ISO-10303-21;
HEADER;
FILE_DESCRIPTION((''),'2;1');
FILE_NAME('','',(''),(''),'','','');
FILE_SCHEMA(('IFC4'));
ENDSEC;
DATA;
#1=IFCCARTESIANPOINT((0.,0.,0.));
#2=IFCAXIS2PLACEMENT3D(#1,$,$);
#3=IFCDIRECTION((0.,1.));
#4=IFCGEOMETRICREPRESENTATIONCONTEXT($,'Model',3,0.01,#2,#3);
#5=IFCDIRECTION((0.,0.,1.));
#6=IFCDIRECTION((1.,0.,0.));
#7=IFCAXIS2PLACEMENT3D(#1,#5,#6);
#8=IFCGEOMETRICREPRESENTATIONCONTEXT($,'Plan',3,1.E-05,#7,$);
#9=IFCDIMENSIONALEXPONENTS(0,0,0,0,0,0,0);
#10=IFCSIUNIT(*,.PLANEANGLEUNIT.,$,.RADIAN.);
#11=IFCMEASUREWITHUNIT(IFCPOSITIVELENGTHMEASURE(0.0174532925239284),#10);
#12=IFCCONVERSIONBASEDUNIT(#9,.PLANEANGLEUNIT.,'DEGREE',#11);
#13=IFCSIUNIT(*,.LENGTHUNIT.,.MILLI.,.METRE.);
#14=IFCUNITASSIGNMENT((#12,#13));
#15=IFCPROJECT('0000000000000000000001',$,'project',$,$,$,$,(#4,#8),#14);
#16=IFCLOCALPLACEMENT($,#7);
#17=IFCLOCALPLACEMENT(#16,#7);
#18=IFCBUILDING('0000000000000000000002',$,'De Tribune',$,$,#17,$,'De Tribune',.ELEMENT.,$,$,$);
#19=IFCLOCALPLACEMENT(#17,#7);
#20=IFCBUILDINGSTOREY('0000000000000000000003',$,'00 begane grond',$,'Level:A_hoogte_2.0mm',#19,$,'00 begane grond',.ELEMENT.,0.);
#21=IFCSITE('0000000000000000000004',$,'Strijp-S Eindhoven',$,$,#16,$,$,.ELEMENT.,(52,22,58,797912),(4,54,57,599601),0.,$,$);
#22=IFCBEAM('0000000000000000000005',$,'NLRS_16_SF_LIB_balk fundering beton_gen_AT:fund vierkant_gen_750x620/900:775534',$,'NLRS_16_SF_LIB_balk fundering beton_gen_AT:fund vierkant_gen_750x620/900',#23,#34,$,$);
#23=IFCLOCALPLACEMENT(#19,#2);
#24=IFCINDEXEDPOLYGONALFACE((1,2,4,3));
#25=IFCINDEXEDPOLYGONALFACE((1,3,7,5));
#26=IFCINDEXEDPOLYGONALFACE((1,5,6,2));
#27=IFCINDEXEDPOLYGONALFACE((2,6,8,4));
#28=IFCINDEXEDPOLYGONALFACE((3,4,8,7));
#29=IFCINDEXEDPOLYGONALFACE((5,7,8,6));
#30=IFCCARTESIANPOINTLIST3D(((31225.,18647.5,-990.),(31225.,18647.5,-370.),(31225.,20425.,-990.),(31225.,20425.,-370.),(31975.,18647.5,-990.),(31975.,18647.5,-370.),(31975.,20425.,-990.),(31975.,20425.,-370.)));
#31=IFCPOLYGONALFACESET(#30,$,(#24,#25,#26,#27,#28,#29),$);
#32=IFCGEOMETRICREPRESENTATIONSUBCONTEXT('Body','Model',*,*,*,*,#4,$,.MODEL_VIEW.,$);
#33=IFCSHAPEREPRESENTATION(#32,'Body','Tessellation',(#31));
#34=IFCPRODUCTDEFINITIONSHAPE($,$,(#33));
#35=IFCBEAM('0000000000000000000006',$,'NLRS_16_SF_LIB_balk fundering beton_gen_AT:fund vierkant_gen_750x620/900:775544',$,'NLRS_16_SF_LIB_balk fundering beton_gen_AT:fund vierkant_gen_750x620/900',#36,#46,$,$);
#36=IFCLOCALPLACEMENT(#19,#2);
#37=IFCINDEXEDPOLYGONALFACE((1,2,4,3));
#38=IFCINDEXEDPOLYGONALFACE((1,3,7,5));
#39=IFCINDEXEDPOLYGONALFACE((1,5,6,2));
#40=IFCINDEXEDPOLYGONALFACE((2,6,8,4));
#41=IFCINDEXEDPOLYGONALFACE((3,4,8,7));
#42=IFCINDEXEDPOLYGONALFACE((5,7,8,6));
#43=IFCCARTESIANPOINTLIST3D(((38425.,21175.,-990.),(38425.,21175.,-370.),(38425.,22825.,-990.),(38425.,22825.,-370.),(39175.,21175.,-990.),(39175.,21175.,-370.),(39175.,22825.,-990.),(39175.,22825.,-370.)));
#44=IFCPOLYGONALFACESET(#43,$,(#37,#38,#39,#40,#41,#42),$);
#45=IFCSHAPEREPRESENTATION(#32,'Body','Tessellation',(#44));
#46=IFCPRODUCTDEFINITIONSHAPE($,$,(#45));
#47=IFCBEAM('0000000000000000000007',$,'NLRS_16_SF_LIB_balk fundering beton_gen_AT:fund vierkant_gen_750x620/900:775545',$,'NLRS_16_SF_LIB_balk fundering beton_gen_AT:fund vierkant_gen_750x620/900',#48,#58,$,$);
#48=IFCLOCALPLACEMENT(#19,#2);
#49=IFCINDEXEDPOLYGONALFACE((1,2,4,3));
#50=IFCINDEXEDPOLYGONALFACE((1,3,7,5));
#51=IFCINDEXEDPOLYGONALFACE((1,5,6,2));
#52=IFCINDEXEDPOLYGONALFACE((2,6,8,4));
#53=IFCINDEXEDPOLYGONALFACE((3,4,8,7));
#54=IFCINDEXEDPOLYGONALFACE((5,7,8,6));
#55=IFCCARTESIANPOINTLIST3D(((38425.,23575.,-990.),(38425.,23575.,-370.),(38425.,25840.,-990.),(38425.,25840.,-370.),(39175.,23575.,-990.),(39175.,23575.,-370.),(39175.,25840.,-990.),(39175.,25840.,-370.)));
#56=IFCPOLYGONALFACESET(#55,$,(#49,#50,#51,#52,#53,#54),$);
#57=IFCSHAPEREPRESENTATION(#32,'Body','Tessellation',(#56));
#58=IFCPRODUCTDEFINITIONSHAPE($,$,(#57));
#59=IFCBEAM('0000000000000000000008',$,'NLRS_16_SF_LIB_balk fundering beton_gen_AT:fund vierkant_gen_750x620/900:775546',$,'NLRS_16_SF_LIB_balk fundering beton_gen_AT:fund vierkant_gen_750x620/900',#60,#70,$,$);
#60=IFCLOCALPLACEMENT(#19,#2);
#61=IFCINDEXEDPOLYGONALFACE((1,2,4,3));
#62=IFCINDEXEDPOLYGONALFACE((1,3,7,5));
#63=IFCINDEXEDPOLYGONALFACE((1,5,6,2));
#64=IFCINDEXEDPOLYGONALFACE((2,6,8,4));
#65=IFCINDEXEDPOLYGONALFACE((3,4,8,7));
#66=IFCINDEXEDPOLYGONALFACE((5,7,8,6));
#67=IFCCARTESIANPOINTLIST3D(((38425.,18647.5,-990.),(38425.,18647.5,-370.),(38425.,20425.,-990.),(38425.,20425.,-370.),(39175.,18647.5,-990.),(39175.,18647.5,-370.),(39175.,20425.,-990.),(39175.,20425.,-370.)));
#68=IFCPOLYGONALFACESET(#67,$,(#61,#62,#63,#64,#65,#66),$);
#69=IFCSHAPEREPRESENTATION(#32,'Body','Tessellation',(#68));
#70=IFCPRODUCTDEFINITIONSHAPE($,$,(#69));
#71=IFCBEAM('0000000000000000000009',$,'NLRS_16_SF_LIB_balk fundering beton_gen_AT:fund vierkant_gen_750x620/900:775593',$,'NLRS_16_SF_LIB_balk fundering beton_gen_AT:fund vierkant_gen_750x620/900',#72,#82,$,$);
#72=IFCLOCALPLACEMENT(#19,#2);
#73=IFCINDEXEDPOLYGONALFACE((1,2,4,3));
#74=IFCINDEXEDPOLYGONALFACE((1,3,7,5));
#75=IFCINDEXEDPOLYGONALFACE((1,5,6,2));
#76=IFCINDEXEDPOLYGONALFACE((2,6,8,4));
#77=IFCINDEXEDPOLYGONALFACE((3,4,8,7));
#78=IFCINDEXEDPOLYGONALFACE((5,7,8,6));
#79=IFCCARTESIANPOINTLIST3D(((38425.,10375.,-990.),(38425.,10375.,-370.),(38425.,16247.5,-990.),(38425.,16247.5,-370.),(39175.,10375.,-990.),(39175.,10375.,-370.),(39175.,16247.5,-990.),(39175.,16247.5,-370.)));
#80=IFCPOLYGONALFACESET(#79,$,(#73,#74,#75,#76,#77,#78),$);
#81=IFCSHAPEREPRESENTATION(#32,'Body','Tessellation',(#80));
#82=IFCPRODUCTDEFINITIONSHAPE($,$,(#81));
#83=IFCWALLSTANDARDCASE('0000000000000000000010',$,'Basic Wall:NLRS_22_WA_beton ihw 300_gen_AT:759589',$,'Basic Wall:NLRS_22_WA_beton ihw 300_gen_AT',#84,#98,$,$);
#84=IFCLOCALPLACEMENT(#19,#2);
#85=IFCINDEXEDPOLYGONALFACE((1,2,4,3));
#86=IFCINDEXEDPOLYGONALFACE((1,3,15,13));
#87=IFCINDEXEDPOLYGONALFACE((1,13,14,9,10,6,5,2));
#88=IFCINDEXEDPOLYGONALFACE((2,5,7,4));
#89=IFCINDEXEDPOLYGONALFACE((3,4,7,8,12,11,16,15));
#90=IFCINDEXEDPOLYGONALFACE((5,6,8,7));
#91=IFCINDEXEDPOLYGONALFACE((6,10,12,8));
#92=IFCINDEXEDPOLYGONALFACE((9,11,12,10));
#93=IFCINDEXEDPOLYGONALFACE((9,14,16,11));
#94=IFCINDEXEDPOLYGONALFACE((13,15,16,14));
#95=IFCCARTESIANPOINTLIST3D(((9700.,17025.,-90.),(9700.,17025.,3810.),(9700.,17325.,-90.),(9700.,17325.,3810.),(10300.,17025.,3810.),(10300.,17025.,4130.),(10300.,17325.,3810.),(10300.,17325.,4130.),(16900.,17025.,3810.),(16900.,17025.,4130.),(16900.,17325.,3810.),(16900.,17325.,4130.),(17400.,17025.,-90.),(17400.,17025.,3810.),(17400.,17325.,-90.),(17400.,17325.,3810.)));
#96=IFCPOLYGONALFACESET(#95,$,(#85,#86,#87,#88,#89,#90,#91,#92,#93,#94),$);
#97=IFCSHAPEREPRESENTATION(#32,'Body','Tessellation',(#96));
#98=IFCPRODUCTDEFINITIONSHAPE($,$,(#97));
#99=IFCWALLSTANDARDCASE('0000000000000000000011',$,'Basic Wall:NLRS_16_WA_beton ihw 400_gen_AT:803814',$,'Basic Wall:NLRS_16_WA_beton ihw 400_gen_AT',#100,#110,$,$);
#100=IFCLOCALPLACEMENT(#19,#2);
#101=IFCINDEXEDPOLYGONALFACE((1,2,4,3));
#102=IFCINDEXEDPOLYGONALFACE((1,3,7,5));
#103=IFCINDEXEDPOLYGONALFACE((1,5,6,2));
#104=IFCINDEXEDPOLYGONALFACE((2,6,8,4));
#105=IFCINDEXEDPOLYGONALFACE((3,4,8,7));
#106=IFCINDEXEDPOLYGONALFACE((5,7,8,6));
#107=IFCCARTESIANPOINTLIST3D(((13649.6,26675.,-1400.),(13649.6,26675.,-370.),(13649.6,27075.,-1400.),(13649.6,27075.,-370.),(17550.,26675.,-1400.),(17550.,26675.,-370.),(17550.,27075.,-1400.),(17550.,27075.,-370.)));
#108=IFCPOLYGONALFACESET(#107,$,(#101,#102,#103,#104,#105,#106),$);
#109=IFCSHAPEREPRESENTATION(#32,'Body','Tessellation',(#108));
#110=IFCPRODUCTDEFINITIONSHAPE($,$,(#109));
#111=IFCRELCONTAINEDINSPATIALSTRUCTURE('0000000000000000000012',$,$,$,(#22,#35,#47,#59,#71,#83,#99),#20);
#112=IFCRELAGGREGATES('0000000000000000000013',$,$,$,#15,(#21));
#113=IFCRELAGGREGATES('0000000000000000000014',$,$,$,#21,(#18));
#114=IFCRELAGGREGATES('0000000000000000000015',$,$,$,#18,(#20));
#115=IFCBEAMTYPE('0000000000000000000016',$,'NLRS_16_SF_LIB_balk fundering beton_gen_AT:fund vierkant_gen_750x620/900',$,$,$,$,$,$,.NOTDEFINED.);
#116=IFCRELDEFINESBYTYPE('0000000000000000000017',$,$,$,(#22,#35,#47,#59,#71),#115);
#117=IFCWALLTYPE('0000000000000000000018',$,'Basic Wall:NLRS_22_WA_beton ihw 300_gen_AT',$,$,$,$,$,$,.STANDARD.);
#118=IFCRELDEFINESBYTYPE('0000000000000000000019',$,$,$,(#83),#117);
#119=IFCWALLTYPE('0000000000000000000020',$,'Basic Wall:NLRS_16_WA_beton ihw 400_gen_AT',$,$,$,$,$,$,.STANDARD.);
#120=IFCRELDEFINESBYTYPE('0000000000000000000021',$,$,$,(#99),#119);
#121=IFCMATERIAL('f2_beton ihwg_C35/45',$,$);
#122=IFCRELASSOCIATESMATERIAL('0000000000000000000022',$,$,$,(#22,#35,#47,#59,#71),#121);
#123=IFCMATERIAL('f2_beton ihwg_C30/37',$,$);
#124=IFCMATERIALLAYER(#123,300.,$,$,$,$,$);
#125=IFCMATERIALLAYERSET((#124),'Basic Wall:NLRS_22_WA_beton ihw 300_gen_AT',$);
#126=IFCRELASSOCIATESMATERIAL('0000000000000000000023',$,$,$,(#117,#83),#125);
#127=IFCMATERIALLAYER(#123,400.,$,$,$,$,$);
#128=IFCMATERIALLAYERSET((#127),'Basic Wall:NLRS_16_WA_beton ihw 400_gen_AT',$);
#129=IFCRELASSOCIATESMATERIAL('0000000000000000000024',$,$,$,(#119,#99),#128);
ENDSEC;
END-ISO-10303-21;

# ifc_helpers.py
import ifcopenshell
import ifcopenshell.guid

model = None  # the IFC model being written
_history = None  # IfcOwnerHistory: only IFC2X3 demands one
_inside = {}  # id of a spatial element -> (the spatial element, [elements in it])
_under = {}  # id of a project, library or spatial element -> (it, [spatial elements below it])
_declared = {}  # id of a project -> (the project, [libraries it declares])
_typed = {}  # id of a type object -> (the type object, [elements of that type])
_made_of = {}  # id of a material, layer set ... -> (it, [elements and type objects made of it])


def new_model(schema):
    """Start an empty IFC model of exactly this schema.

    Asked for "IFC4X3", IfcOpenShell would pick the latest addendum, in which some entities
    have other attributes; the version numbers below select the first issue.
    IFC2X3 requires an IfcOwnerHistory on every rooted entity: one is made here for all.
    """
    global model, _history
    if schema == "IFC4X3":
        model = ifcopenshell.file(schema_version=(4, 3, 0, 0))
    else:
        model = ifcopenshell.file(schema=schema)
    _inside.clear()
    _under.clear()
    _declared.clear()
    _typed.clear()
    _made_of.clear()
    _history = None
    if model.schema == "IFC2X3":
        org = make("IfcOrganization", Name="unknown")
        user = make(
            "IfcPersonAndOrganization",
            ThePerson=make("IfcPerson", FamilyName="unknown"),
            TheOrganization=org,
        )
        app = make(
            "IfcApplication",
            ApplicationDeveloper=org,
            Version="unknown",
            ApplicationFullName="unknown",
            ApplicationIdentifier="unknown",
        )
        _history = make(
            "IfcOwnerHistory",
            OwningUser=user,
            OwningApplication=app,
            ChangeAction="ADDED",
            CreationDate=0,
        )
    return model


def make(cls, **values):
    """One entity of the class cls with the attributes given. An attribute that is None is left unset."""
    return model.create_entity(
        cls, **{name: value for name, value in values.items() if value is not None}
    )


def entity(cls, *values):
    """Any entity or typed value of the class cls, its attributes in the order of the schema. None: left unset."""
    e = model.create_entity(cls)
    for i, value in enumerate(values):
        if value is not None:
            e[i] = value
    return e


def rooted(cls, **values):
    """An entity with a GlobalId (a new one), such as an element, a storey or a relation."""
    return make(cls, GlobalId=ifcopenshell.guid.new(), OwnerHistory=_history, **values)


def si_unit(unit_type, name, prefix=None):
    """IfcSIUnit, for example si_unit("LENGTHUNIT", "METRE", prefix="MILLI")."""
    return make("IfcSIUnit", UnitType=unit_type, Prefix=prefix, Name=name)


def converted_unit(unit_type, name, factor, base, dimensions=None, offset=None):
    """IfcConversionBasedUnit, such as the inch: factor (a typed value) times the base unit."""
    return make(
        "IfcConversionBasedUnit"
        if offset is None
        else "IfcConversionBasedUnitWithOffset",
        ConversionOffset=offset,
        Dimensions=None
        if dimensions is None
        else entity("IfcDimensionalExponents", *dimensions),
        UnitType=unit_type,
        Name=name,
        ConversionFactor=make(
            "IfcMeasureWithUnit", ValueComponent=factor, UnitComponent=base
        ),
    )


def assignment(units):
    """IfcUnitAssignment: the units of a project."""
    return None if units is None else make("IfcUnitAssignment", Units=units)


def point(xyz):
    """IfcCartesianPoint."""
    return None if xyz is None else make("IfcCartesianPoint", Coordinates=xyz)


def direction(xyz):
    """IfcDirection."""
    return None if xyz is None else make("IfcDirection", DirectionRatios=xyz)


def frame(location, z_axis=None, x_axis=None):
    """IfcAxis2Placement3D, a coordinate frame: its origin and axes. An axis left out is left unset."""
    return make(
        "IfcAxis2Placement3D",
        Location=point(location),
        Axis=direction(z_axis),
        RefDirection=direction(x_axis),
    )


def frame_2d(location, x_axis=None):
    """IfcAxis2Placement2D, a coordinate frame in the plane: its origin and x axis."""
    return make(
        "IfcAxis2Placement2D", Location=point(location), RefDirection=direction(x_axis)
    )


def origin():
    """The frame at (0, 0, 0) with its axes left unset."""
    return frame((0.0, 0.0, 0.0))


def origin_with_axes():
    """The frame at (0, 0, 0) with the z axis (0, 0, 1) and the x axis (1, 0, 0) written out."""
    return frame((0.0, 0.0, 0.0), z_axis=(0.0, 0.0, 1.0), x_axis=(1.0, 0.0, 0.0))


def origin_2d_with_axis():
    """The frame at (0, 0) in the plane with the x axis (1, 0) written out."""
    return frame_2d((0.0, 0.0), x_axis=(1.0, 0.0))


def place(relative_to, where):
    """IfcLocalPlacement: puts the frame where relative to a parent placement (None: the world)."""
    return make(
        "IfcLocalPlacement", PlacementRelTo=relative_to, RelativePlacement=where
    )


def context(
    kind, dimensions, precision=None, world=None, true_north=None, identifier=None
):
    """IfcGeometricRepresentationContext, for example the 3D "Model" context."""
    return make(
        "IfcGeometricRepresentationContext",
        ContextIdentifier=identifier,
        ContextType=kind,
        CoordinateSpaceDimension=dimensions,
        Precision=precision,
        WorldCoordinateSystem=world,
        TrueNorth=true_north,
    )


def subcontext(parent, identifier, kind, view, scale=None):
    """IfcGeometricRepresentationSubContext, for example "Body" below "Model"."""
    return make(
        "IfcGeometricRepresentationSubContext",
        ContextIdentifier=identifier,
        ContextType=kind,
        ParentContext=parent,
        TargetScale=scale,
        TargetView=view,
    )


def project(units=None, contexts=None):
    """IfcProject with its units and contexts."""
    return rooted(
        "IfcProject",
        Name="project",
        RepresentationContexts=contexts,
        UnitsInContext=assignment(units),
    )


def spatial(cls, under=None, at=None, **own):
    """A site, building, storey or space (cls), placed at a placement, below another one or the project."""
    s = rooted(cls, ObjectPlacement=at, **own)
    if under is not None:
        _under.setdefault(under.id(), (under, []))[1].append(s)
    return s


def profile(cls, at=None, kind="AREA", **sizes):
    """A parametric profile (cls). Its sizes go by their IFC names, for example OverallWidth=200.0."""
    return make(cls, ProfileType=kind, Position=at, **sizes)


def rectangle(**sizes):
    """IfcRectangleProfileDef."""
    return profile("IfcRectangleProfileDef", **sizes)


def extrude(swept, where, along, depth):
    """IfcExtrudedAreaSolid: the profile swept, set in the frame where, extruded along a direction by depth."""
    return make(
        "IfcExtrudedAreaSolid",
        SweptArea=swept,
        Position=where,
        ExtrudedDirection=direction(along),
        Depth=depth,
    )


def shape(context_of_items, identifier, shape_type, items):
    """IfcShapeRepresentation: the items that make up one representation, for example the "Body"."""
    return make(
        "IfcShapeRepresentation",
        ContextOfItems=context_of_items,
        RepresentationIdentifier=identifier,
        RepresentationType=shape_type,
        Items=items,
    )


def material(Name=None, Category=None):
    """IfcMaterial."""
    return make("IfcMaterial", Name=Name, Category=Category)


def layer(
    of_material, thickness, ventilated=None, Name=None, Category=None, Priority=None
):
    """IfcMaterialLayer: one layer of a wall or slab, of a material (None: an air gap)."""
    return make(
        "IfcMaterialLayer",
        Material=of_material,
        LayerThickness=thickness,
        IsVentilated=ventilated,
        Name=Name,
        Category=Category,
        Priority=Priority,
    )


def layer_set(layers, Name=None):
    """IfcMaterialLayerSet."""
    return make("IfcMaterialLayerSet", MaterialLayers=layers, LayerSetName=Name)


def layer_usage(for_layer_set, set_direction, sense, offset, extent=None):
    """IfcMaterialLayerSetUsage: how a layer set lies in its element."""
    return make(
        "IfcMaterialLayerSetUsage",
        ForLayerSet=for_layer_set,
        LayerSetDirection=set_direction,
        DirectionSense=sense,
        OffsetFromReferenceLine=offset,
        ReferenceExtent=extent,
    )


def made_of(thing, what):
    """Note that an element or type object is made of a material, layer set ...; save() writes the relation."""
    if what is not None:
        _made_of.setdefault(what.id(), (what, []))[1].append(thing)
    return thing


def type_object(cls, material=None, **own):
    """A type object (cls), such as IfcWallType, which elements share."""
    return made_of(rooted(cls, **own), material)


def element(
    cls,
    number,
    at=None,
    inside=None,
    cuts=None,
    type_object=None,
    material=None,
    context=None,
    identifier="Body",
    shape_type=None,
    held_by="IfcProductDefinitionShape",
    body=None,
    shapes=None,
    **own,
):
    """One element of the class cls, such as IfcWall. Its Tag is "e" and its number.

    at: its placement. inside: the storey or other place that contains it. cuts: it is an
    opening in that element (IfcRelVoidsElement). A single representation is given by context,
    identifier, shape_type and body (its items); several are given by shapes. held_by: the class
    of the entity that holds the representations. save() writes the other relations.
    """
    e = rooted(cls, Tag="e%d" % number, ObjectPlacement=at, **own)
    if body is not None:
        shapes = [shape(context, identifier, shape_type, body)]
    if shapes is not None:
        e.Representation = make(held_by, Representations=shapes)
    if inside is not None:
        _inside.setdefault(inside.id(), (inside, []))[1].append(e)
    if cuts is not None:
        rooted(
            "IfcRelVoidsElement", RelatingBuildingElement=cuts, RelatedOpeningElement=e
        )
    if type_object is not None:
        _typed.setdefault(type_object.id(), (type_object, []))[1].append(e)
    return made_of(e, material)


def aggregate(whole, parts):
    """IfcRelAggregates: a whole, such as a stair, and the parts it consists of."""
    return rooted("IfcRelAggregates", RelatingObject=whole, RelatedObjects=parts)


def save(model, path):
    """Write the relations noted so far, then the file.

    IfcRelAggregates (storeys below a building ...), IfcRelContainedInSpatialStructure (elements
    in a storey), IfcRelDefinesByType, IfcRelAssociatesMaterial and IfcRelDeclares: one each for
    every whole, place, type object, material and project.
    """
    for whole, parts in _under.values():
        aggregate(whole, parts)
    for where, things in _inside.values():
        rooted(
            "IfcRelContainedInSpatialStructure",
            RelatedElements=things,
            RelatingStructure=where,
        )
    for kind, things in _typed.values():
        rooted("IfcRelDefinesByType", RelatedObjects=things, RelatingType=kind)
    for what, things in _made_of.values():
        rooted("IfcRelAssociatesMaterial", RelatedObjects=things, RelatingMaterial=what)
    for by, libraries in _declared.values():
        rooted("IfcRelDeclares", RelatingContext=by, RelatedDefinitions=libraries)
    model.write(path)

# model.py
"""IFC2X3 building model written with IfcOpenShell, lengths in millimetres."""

from ifc_helpers import new_model, entity, si_unit, converted_unit, direction, frame, frame_2d, origin, origin_with_axes, origin_2d_with_axis, place, context, subcontext, project, spatial, rectangle, extrude, material, layer, layer_set, layer_usage, type_object, element, save


model = new_model("IFC2X3")

# Units and contexts
model_context = context("Model", 3, precision=0.01, world=origin(), true_north=direction((0.0, 1.0)))
plan_context = context("Plan", 3, precision=1e-05, world=origin_with_axes())
body_context = subcontext(model_context, "Body", "Model", "MODEL_VIEW")
ifc_project = project(units=[converted_unit("PLANEANGLEUNIT", "DEGREE", entity("IfcPositiveLengthMeasure", 0.0174532925239284), si_unit("PLANEANGLEUNIT", "RADIAN"), dimensions=[0, 0, 0, 0, 0, 0, 0]), si_unit("LENGTHUNIT", "METRE", prefix="MILLI")], contexts=[model_context, plan_context])

# Site, building, storey
site_placement = place(None, origin_with_axes())
site = spatial("IfcSite", under=ifc_project, at=site_placement, Name="Strijp-S Eindhoven", CompositionType="ELEMENT", RefLatitude=(52, 22, 58, 797912), RefLongitude=(4, 54, 57, 599601), RefElevation=0.0)
building_placement = place(site_placement, origin_with_axes())
building = spatial("IfcBuilding", under=site, at=building_placement, Name="De Tribune", LongName="De Tribune", CompositionType="ELEMENT")
storey_placement = place(building_placement, origin_with_axes())
storey = spatial("IfcBuildingStorey", under=building, at=storey_placement, Name="00 begane grond", ObjectType="Level:A_hoogte_2.0mm", LongName="00 begane grond", CompositionType="ELEMENT", Elevation=0.0)

# Beams
ifc_material_1 = material(Name="f2_beton ihwg_C35/45")
beam_type_1 = type_object("IfcBeamType", Name="NLRS_16_SF_LIB_balk fundering beton_gen_AT:fund vierkant_gen_750x620/900", PredefinedType="NOTDEFINED")
beam_1_placement = place(storey_placement, frame((31600.0, 18647.5, 0.0), z_axis=(0.0, 0.0, 1.0), x_axis=(0.0, 1.0, 0.0)))
element("IfcBeam", 1, at=beam_1_placement, inside=storey, type_object=beam_type_1, material=ifc_material_1, Name="NLRS_16_SF_LIB_balk fundering beton_gen_AT:fund vierkant_gen_750x620/900:775534", ObjectType="NLRS_16_SF_LIB_balk fundering beton_gen_AT:fund vierkant_gen_750x620/900", context=body_context, shape_type="SweptSolid", body=[
    extrude(rectangle(XDim=620.0, YDim=750.0, at=frame_2d((0.0, 0.0), x_axis=(1.0, 0.0))), frame((0.0, 0.0, -680.0), z_axis=(1.0, 0.0, 0.0), x_axis=(0.0, 0.0, -1.0)), (0.0, 0.0, 1.0), 1777.5),
])
beam_2_placement = place(storey_placement, frame((38800.0, 21175.0, 0.0), z_axis=(0.0, 0.0, 1.0), x_axis=(0.0, 1.0, 0.0)))
element("IfcBeam", 2, at=beam_2_placement, inside=storey, type_object=beam_type_1, material=ifc_material_1, Name="NLRS_16_SF_LIB_balk fundering beton_gen_AT:fund vierkant_gen_750x620/900:775544", ObjectType="NLRS_16_SF_LIB_balk fundering beton_gen_AT:fund vierkant_gen_750x620/900", context=body_context, shape_type="SweptSolid", body=[
    extrude(rectangle(XDim=620.0, YDim=750.0, at=origin_2d_with_axis()), frame((0.0, 0.0, -680.0), z_axis=(1.0, 0.0, 0.0), x_axis=(0.0, 0.0, -1.0)), (0.0, 0.0, 1.0), 1650.0),
])
beam_3_placement = place(storey_placement, frame((38800.0, 23575.0, 0.0), z_axis=(0.0, 0.0, 1.0), x_axis=(0.0, 1.0, 0.0)))
element("IfcBeam", 3, at=beam_3_placement, inside=storey, type_object=beam_type_1, material=ifc_material_1, Name="NLRS_16_SF_LIB_balk fundering beton_gen_AT:fund vierkant_gen_750x620/900:775545", ObjectType="NLRS_16_SF_LIB_balk fundering beton_gen_AT:fund vierkant_gen_750x620/900", context=body_context, shape_type="SweptSolid", body=[
    extrude(rectangle(XDim=620.0, YDim=750.0, at=frame_2d((0.0, 0.0), x_axis=(1.0, 0.0))), frame((0.0, 0.0, -680.0), z_axis=(1.0, 0.0, 0.0), x_axis=(0.0, 0.0, -1.0)), (0.0, 0.0, 1.0), 2265.0),
])
beam_4_placement = place(storey_placement, frame((38800.0, 18647.5, 0.0), z_axis=(0.0, 0.0, 1.0), x_axis=(0.0, 1.0, 0.0)))
element("IfcBeam", 4, at=beam_4_placement, inside=storey, type_object=beam_type_1, material=ifc_material_1, Name="NLRS_16_SF_LIB_balk fundering beton_gen_AT:fund vierkant_gen_750x620/900:775546", ObjectType="NLRS_16_SF_LIB_balk fundering beton_gen_AT:fund vierkant_gen_750x620/900", context=body_context, shape_type="SweptSolid", body=[
    extrude(rectangle(XDim=620.0, YDim=750.0, at=frame_2d((0.0, 0.0), x_axis=(1.0, 0.0))), frame((0.0, 0.0, -680.0), z_axis=(1.0, 0.0, 0.0), x_axis=(0.0, 0.0, -1.0)), (0.0, 0.0, 1.0), 1777.5),
])
beam_5_placement = place(storey_placement, frame((38800.0, 10375.0, 0.0), z_axis=(0.0, 0.0, 1.0), x_axis=(0.0, 1.0, 0.0)))
element("IfcBeam", 5, at=beam_5_placement, inside=storey, type_object=beam_type_1, material=ifc_material_1, Name="NLRS_16_SF_LIB_balk fundering beton_gen_AT:fund vierkant_gen_750x620/900:775593", ObjectType="NLRS_16_SF_LIB_balk fundering beton_gen_AT:fund vierkant_gen_750x620/900", context=body_context, shape_type="SweptSolid", body=[
    extrude(rectangle(XDim=620.0, YDim=750.0, at=frame_2d((0.0, 0.0), x_axis=(1.0, 0.0))), frame((0.0, 0.0, -680.0), z_axis=(1.0, 0.0, 0.0), x_axis=(0.0, 0.0, -1.0)), (0.0, 0.0, 1.0), 5872.5),
])

# Wall, openings
ifc_material_2 = material(Name="f2_beton ihwg_C30/37")
ifc_layer_1 = layer(ifc_material_2, 300.0)
ifc_layer_set_1 = layer_set([ifc_layer_1], Name="Basic Wall:NLRS_22_WA_beton ihw 300_gen_AT")
ifc_layer_usage_1 = layer_usage(ifc_layer_set_1, "AXIS2", "NEGATIVE", 150.0)
wall_type_1 = type_object("IfcWallType", Name="Basic Wall:NLRS_22_WA_beton ihw 300_gen_AT", PredefinedType="STANDARD", material=ifc_layer_set_1)
wall_1_placement = place(storey_placement, frame((17400.0, 17175.0, -90.0), z_axis=(0.0, 0.0, 1.0), x_axis=(-1.0, 0.0, 0.0)))
wall_1 = element("IfcWallStandardCase", 6, at=wall_1_placement, inside=storey, type_object=wall_type_1, material=ifc_layer_usage_1, Name="Basic Wall:NLRS_22_WA_beton ihw 300_gen_AT:759589", ObjectType="Basic Wall:NLRS_22_WA_beton ihw 300_gen_AT", context=body_context, shape_type="SweptSolid", body=[
    extrude(rectangle(XDim=7700.0, YDim=300.0, at=frame_2d((3850.0, 0.0), x_axis=(-1.0, 0.0))), origin(), (0.0, 0.0, 1.0), 4220.0),
])
opening_1_placement = place(wall_1_placement, origin_with_axes())
element("IfcOpeningElement", 7, at=opening_1_placement, cuts=wall_1, ObjectType="Opening", context=body_context, shape_type="SweptSolid", body=[
    extrude(rectangle(XDim=320.0, YDim=600.0, at=frame_2d((0.0, 0.0), x_axis=(1.0, 0.0))), frame((7400.0, 150.0, 4060.0), z_axis=(0.0, -1.0, 0.0), x_axis=(0.0, 0.0, 1.0)), (0.0, 0.0, 1.0), 300.0),
])
opening_2_placement = place(wall_1_placement, origin_with_axes())
element("IfcOpeningElement", 8, at=opening_2_placement, cuts=wall_1, ObjectType="Opening", context=body_context, shape_type="SweptSolid", body=[
    extrude(rectangle(XDim=320.0, YDim=500.0, at=frame_2d((0.0, 0.0), x_axis=(0.0, 1.0))), frame((250.0, 150.0, 4060.0), z_axis=(0.0, -1.0, 0.0), x_axis=(-1.0, 0.0, 0.0)), (0.0, 0.0, 1.0), 300.0),
])

# Wall
ifc_layer_2 = layer(ifc_material_2, 400.0)
ifc_layer_set_2 = layer_set([ifc_layer_2], Name="Basic Wall:NLRS_16_WA_beton ihw 400_gen_AT")
ifc_layer_usage_2 = layer_usage(ifc_layer_set_2, "AXIS2", "POSITIVE", -200.0)
wall_type_2 = type_object("IfcWallType", Name="Basic Wall:NLRS_16_WA_beton ihw 400_gen_AT", PredefinedType="STANDARD", material=ifc_layer_set_2)
wall_2_placement = place(storey_placement, frame((17550.0, 26875.0, -1400.0), z_axis=(0.0, 0.0, 1.0), x_axis=(-1.0, 0.0, 0.0)))
element("IfcWallStandardCase", 9, at=wall_2_placement, inside=storey, type_object=wall_type_2, material=ifc_layer_usage_2, Name="Basic Wall:NLRS_16_WA_beton ihw 400_gen_AT:803814", ObjectType="Basic Wall:NLRS_16_WA_beton ihw 400_gen_AT", context=body_context, shape_type="SweptSolid", body=[
    extrude(rectangle(XDim=3900.4, YDim=400.0, at=frame_2d((1950.2, 0.0), x_axis=(-1.0, 0.0))), origin(), (0.0, 0.0, 1.0), 1030.0),
])

save(model, "model.ifc")
